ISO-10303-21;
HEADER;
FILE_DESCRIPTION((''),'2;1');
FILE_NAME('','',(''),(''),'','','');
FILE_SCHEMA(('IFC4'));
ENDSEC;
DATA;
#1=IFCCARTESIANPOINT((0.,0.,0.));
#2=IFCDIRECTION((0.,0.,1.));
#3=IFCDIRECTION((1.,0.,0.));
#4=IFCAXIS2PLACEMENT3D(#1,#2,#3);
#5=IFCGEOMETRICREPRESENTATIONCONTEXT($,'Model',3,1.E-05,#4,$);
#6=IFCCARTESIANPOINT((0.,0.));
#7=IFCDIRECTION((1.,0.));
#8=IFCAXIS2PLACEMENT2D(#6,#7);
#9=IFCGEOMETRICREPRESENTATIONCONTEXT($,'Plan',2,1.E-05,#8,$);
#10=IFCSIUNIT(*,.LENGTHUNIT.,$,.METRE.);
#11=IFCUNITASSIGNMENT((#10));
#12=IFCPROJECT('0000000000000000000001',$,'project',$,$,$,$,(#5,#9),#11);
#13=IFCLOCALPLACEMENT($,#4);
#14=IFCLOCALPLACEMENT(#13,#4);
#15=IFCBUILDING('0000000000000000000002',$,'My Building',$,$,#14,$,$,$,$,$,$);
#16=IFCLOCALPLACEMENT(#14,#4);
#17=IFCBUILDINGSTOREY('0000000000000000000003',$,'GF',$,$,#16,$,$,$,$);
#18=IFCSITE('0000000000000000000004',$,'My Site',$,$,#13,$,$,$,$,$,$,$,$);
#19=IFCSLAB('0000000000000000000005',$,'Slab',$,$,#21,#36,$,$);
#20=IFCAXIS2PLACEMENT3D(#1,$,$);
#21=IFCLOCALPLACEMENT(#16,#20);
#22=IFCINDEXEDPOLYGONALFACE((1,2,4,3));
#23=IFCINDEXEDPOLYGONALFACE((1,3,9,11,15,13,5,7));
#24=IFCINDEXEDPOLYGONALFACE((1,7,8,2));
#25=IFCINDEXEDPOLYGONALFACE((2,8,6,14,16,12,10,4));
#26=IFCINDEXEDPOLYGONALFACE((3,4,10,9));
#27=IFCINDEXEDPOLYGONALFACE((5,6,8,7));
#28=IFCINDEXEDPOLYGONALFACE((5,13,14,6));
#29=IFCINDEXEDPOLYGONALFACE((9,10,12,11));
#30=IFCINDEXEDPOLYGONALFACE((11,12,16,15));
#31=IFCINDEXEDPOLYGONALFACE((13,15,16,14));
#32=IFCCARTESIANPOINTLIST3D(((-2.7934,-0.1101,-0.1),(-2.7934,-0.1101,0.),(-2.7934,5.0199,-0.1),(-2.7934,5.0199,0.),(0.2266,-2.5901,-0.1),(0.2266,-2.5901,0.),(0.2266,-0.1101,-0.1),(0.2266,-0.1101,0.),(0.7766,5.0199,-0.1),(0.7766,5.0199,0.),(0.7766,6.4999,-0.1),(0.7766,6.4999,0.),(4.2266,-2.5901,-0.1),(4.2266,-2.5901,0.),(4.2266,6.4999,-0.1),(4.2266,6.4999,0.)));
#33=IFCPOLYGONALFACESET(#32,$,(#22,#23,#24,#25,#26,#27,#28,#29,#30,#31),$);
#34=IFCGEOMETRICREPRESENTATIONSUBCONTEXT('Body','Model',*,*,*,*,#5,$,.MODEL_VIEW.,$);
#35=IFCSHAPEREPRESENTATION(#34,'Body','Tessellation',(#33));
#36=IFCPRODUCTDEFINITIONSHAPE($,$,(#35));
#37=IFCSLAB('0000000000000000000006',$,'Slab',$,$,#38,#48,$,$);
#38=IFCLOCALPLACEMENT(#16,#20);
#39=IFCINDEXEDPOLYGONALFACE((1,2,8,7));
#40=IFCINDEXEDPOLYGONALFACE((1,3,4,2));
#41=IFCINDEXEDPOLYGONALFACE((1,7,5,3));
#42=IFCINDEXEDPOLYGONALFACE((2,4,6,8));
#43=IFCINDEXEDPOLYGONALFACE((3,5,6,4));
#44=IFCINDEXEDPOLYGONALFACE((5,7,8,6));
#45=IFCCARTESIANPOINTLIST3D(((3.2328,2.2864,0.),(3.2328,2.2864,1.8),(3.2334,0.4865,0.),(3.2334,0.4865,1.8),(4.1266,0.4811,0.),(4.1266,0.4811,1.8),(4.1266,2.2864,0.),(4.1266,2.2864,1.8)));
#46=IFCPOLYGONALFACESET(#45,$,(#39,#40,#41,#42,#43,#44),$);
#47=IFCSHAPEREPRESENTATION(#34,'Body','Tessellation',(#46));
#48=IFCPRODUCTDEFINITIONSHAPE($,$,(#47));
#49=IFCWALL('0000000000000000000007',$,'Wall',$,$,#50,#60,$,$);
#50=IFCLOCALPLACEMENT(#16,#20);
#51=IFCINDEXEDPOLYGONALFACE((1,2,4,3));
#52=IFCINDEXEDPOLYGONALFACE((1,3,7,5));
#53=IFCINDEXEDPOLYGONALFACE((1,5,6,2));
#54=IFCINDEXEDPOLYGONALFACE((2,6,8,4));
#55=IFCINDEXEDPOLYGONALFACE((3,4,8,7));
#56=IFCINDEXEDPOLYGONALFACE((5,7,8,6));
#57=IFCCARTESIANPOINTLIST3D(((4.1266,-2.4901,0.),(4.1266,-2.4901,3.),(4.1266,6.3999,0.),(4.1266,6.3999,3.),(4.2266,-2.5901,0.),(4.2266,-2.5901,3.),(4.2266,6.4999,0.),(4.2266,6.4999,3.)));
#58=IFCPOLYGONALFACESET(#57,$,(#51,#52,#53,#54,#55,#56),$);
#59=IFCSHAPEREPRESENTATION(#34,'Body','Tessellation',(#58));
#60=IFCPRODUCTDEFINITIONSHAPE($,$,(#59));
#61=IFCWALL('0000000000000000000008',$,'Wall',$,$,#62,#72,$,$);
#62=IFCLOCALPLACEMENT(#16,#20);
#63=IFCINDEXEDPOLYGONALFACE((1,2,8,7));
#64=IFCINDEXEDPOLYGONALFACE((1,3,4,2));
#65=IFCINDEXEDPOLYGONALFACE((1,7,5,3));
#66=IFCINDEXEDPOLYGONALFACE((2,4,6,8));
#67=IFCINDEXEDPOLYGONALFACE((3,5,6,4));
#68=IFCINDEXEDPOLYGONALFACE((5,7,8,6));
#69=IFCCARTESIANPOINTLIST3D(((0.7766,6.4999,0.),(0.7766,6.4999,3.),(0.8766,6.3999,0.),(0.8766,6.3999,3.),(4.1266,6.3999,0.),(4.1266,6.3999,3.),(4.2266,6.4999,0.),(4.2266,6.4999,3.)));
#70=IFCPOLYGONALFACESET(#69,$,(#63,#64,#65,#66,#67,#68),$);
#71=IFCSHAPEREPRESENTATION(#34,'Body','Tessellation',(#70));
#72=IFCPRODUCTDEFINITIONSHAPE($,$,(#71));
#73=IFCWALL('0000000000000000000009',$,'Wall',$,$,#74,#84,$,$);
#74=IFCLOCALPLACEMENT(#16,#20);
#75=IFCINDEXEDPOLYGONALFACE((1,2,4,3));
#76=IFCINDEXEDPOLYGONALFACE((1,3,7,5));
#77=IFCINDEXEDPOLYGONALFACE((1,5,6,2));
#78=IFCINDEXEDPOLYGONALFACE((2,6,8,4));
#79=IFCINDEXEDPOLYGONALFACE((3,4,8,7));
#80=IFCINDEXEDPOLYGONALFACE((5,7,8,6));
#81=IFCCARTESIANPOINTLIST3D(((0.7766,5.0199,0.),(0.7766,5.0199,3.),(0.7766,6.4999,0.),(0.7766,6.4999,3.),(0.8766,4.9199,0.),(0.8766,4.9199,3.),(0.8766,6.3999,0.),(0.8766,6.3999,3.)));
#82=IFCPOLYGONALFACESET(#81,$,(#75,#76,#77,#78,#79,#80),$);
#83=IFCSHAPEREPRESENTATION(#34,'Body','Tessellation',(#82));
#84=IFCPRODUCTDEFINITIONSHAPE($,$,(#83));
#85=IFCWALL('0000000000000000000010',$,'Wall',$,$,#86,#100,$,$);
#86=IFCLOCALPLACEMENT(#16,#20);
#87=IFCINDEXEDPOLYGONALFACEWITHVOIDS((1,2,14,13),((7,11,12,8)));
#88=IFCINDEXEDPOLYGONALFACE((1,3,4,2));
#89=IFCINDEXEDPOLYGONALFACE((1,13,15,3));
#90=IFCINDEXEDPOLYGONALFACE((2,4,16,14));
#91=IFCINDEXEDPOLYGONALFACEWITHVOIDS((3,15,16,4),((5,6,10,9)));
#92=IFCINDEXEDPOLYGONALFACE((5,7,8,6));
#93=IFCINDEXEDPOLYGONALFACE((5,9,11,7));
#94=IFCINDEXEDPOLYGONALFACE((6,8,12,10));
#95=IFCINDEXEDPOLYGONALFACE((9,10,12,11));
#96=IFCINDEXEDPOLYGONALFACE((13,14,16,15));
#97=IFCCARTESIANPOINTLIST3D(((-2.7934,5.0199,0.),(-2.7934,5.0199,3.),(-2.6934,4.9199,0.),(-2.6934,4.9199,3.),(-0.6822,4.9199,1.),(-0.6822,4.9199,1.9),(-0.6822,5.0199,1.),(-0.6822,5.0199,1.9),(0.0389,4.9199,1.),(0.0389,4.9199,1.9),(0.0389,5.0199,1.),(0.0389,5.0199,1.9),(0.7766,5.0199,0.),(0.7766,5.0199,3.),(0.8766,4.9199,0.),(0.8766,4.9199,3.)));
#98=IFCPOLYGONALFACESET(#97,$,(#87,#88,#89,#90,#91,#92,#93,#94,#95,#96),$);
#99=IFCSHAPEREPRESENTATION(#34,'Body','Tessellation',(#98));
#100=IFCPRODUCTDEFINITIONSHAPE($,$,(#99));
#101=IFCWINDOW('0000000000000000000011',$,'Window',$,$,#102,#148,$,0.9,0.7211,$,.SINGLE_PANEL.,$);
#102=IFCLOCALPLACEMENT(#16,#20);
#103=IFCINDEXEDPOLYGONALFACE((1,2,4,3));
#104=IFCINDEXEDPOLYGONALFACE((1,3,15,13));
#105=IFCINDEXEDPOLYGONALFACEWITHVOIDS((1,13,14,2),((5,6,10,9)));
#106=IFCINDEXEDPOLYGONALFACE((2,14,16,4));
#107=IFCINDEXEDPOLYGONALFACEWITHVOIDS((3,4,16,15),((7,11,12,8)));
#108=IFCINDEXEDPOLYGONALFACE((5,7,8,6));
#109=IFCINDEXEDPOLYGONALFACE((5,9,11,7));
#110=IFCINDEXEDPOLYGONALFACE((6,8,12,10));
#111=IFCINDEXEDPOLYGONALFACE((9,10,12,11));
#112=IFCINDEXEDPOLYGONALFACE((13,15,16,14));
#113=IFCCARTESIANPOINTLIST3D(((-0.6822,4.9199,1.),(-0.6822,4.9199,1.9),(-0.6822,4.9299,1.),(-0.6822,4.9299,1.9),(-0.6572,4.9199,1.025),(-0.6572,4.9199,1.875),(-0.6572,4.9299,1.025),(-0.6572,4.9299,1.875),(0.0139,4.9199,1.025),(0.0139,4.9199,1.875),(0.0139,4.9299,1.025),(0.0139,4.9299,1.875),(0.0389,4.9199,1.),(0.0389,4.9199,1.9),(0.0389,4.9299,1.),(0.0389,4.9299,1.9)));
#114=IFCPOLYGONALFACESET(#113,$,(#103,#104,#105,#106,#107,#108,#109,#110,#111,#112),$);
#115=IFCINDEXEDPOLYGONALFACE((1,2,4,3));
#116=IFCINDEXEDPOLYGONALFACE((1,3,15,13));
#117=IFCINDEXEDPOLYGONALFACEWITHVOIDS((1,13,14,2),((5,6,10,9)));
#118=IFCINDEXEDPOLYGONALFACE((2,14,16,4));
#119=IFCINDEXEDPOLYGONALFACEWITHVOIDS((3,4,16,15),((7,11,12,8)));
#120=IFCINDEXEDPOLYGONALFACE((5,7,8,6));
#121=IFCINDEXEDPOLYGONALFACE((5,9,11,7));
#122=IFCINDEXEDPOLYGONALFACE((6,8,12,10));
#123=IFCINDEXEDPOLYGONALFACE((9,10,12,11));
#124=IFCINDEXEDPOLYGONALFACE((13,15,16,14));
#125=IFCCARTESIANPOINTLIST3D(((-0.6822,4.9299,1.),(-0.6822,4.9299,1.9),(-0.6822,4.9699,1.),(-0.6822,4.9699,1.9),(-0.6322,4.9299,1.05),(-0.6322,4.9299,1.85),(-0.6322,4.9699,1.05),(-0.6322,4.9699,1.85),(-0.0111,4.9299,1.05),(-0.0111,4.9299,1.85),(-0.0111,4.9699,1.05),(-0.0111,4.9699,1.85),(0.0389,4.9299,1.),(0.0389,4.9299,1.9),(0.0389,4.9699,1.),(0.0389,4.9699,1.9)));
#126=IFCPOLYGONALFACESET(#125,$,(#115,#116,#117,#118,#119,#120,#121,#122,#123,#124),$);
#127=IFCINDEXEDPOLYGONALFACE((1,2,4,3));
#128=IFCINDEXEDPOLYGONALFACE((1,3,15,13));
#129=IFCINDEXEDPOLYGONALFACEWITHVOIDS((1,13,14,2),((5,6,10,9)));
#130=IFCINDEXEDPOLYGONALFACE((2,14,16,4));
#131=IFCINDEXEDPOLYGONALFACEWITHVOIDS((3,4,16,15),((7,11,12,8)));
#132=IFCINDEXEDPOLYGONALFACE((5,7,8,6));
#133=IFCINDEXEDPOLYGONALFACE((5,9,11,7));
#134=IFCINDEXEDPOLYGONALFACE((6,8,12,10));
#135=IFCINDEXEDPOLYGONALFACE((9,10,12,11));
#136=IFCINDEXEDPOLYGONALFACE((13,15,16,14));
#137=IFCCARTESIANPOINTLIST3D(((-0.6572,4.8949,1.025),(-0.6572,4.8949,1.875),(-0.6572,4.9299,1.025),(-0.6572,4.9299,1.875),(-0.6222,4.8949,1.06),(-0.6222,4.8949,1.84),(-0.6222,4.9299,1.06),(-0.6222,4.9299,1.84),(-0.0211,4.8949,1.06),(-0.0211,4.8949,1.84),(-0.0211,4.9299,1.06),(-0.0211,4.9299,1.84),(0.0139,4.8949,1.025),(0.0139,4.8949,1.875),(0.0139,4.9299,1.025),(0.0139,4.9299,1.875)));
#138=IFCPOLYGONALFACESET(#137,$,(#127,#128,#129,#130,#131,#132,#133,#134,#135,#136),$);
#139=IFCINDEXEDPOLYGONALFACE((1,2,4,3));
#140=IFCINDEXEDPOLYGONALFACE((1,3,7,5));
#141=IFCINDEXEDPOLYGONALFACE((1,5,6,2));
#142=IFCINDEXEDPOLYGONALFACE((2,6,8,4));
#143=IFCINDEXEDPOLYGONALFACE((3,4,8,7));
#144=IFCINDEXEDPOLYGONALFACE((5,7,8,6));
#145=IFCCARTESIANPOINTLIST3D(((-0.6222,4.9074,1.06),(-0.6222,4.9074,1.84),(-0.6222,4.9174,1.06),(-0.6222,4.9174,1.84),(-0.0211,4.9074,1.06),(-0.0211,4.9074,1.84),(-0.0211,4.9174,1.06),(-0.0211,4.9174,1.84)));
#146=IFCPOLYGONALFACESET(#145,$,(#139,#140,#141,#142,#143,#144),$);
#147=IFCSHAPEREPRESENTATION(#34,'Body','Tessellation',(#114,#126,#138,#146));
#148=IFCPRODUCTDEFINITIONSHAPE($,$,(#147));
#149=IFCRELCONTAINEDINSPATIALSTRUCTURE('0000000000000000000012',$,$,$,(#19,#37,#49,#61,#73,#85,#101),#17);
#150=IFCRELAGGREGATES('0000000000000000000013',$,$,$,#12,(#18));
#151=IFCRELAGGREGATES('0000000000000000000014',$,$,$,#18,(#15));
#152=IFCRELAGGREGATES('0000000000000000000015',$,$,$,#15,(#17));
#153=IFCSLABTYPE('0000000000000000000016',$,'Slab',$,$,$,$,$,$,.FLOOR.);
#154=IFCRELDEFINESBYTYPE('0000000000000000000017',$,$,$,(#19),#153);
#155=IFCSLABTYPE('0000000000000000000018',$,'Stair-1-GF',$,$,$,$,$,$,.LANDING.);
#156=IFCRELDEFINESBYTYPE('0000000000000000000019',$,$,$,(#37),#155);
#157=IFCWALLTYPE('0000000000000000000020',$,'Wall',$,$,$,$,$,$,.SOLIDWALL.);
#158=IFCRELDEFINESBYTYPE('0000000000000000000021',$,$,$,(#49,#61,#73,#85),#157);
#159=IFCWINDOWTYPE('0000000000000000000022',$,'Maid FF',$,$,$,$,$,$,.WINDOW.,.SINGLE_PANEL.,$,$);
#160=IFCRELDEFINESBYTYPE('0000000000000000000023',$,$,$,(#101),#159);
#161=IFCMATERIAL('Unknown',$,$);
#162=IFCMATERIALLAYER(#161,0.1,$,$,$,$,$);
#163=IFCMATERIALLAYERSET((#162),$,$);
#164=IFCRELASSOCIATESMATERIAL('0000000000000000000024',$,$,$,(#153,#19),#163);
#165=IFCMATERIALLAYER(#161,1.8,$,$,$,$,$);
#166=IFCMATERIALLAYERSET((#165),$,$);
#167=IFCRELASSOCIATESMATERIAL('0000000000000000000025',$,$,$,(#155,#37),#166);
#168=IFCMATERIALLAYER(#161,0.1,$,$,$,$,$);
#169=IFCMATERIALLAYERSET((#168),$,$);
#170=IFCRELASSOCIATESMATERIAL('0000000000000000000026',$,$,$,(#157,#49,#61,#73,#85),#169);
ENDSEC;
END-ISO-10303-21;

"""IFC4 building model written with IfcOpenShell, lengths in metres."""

from ifc_helpers import new_model, entity, si_unit, frame, origin_with_axes, origin_2d_with_axis, place, context, subcontext, project, spatial, line, indexed_curve, outline, extrude, shape, source, transform, mapped, material, layer, layer_set, layer_usage, type_object, type_shapes, element, fill, save


model = new_model("IFC4")

# Units and contexts
model_context = context("Model", 3, precision=1e-05, world=origin_with_axes())
plan_context = context("Plan", 2, precision=1e-05, world=origin_2d_with_axis())
body_context_1 = subcontext(model_context, "Body", "Model", "MODEL_VIEW")
body_context_2 = subcontext(plan_context, "Body", "Plan", "PLAN_VIEW")
ifc_project = project(units=[si_unit("LENGTHUNIT", "METRE")], contexts=[model_context, plan_context])

# Site, building, storey
site_placement = place(None, origin_with_axes())
site = spatial("IfcSite", under=ifc_project, at=site_placement, Name="My Site")
building_placement = place(site_placement, origin_with_axes())
building = spatial("IfcBuilding", under=site, at=building_placement, Name="My Building")
storey_placement = place(building_placement, origin_with_axes())
storey = spatial("IfcBuildingStorey", under=building, at=storey_placement, Name="GF")

# Slabs
ifc_material_1 = material(Name="Unknown")
ifc_layer_1 = layer(ifc_material_1, 0.1)
ifc_layer_set_1 = layer_set([ifc_layer_1])
ifc_layer_usage_1 = layer_usage(ifc_layer_set_1, "AXIS3", "POSITIVE", -0.1)
slab_type_1 = type_object("IfcSlabType", Name="Slab", PredefinedType="FLOOR", material=ifc_layer_set_1)
slab_1_placement = place(storey_placement, frame((4.2266, -2.5901, 0.0), z_axis=(0.0, 0.0, 1.0), x_axis=(1.0, 0.0, 0.0)))
element("IfcSlab", 1, at=slab_1_placement, inside=storey, type_object=slab_type_1, material=ifc_layer_usage_1, Name="Slab", context=body_context_1, shape_type="SweptSolid", body=[
    extrude(outline(indexed_curve([(0.0, 0.0), (0.0, 9.09), (-3.45, 9.09), (-3.45, 7.61), (-7.02, 7.61), (-7.02, 2.48), (-4.0, 2.48), (-4.0, 0.0), (0.0, 0.0)])), frame((0.0, 0.0, -0.1), z_axis=(0.0, 0.0, 1.0), x_axis=(1.0, 0.0, 0.0)), (0.0, 0.0, 1.0), 0.1),
])
ifc_layer_2 = layer(ifc_material_1, 1.8)
ifc_layer_set_2 = layer_set([ifc_layer_2])
ifc_layer_usage_2 = layer_usage(ifc_layer_set_2, "AXIS3", "POSITIVE", -0.1)
slab_type_2 = type_object("IfcSlabType", Name="Stair-1-GF", PredefinedType="LANDING", material=ifc_layer_set_2)
slab_2_placement = place(storey_placement, frame((3.2334, 0.4865, 0.1), z_axis=(0.0, 0.0, 1.0), x_axis=(1.0, 0.0, 0.0)))
element("IfcSlab", 2, at=slab_2_placement, inside=storey, type_object=slab_type_2, material=ifc_layer_usage_2, Name="Slab", context=body_context_1, shape_type="SweptSolid", body=[
    extrude(outline(indexed_curve([(-0.0006, 1.7999), (0.8932, 1.7999), (0.8932, -0.0054), (0.0, 0.0), (-0.0006, 1.7999)])), frame((0.0, 0.0, -0.1), z_axis=(0.0, 0.0, 1.0), x_axis=(1.0, 0.0, 0.0)), (0.0, 0.0, 1.0), 1.8),
])

# Shared definitions
ifc_layer_3 = layer(ifc_material_1, 0.1)
ifc_layer_set_3 = layer_set([ifc_layer_3])
wall_type = type_object("IfcWallType", Name="Wall", PredefinedType="SOLIDWALL", material=ifc_layer_set_3)

# Walls
ifc_layer_usage_3 = layer_usage(ifc_layer_set_3, "AXIS2", "POSITIVE", 0.0)
wall_1_placement = place(storey_placement, frame((4.2266, -2.5901, 0.0), z_axis=(0.0, 0.0, 1.0), x_axis=(0.0, 1.0, 0.0)))
element("IfcWall", 3, at=wall_1_placement, inside=storey, type_object=wall_type, material=ifc_layer_usage_3, Name="Wall", context=body_context_1, shape_type="SweptSolid", body=[
    extrude(outline(indexed_curve([(0.0, 0.0), (0.1, 0.1), (8.99, 0.1), (9.09, 0.0)], segments=[line(1, 2, 3, 4, 1)])), origin_with_axes(), (0.0, 0.0, 1.0), 3.0),
])
ifc_layer_usage_4 = layer_usage(ifc_layer_set_3, "AXIS2", "POSITIVE", 0.0)
wall_2_placement = place(storey_placement, frame((4.2266, 6.4999, 0.0), z_axis=(0.0, 0.0, 1.0), x_axis=(-1.0, 0.0, 0.0)))
element("IfcWall", 4, at=wall_2_placement, inside=storey, type_object=wall_type, material=ifc_layer_usage_4, Name="Wall", context=body_context_1, shape_type="SweptSolid", body=[
    extrude(outline(indexed_curve([(0.0, 0.0), (0.1, 0.1), (3.35, 0.1), (3.45, 0.0)], segments=[line(1, 2, 3, 4, 1)])), origin_with_axes(), (0.0, 0.0, 1.0), 3.0),
])
ifc_layer_usage_5 = layer_usage(ifc_layer_set_3, "AXIS2", "POSITIVE", 0.0)
wall_3_placement = place(storey_placement, frame((0.7766, 6.4999, 0.0), z_axis=(0.0, 0.0, 1.0), x_axis=(0.0, -1.0, 0.0)))
element("IfcWall", 5, at=wall_3_placement, inside=storey, type_object=wall_type, material=ifc_layer_usage_5, Name="Wall", context=body_context_1, shape_type="SweptSolid", body=[
    extrude(outline(indexed_curve([(0.0, 0.0), (0.1, 0.1), (1.58, 0.1), (1.48, 0.0)], segments=[line(1, 2, 3, 4, 1)])), origin_with_axes(), (0.0, 0.0, 1.0), 3.0),
])

# Wall, opening, window
ifc_layer_usage_6 = layer_usage(ifc_layer_set_3, "AXIS2", "POSITIVE", 0.0)
wall_4_placement = place(storey_placement, frame((0.7766, 5.0199, 0.0), z_axis=(0.0, 0.0, 1.0), x_axis=(-1.0, 0.0, 0.0)))
wall_4 = element("IfcWall", 6, at=wall_4_placement, inside=storey, type_object=wall_type, material=ifc_layer_usage_6, Name="Wall", context=body_context_1, shape_type="SweptSolid", body=[
    extrude(outline(indexed_curve([(0.0, 0.0), (-0.1, 0.1), (3.47, 0.1), (3.57, 0.0)], segments=[line(1, 2, 3, 4, 1)])), origin_with_axes(), (0.0, 0.0, 1.0), 3.0),
])
shared_shape_1 = source(origin_with_axes(), body_context_1, "Body", "SweptSolid", [
    extrude(outline(indexed_curve([(0.0, 0.0), (0.7211, 0.0), (0.7211, 0.9), (0.0, 0.9)], segments=[line(1, 2, 3, 4, 1)])), frame((0.0, -0.6, 0.0), z_axis=(0.0, -1.0, 0.0), x_axis=(1.0, 0.0, 0.0)), (0.0, 0.0, -1.0), 1.2),
])
opening_1_placement = place(wall_4_placement, frame((0.7377, 0.0, 1.0), z_axis=(0.0, 0.0, 1.0), x_axis=(1.0, 0.0, 0.0)))
opening_1 = element("IfcOpeningElement", 7, at=opening_1_placement, cuts=wall_4, PredefinedType="OPENING", context=body_context_1, shape_type="MappedRepresentation", body=[
    mapped(shared_shape_1, transform((0.0, 0.0, 0.0), x_axis=(1.0, 0.0, 0.0), y_axis=(0.0, 1.0, 0.0), z_axis=(0.0, 0.0, 1.0), scale=1.0)),
])
window_type_1 = type_object("IfcWindowType", Name="Maid FF", PartitioningType="SINGLE_PANEL", PredefinedType="WINDOW")
shared_shape_2 = source(origin_with_axes(), body_context_1, "Body", "SweptSolid", [
    extrude(outline(indexed_curve([(0.0, 0.0), (0.7211, 0.0), (0.7211, 0.9), (0.0, 0.9)], segments=[line(1, 2, 3, 4, 1)]), holes=[indexed_curve([(0.025, 0.025), (0.6961, 0.025), (0.6961, 0.875), (0.025, 0.875)], segments=[line(1, 2, 3, 4, 1)])]), frame((0.0, 0.09, 0.0), z_axis=(0.0, -1.0, 0.0), x_axis=(1.0, 0.0, 0.0)), (0.0, 0.0, -1.0), 0.01),
    extrude(outline(indexed_curve([(0.0, 0.0), (0.7211, 0.0), (0.7211, 0.9), (0.0, 0.9)], segments=[line(1, 2, 3, 4, 1)]), holes=[indexed_curve([(0.05, 0.05), (0.6711, 0.05), (0.6711, 0.85), (0.05, 0.85)], segments=[line(1, 2, 3, 4, 1)])]), frame((0.0, 0.05, 0.0), z_axis=(0.0, -1.0, 0.0), x_axis=(1.0, 0.0, 0.0)), (0.0, 0.0, -1.0), 0.04),
    extrude(outline(indexed_curve([(0.0, 0.0), (0.6711, 0.0), (0.6711, 0.85), (0.0, 0.85)], segments=[line(1, 2, 3, 4, 1)]), holes=[indexed_curve([(0.035, 0.035), (0.6361, 0.035), (0.6361, 0.815), (0.035, 0.815)], segments=[line(1, 2, 3, 4, 1)])]), frame((0.025, 0.09, 0.025), z_axis=(0.0, -1.0, 0.0), x_axis=(1.0, 0.0, 0.0)), (0.0, 0.0, -1.0), 0.035),
    extrude(outline(indexed_curve([(0.035, 0.035), (0.6361, 0.035), (0.6361, 0.815), (0.035, 0.815)], segments=[line(1, 2, 3, 4, 1)])), frame((0.025, 0.1025, 0.025), z_axis=(0.0, -1.0, 0.0), x_axis=(1.0, 0.0, 0.0)), (0.0, 0.0, -1.0), 0.01),
])
shared_shape_3 = source(origin_with_axes(), body_context_2, "Body", "Curve2D", [
    entity("IfcIndexedPolyCurve", entity("IfcCartesianPointList2D", [[0.05, 0.05], [0.6711, 0.05]])),
    entity("IfcIndexedPolyCurve", entity("IfcCartesianPointList2D", [[0.0, 0.1], [0.025, 0.1], [0.025, 0.09], [0.05, 0.09], [0.05, 0.05], [0.0, 0.05]]), [entity("IfcLineIndex", [1, 2, 3, 4, 5, 6, 1])]),
    entity("IfcIndexedPolyCurve", entity("IfcCartesianPointList2D", [[0.7211, 0.1], [0.6961, 0.1], [0.6961, 0.09], [0.6711, 0.09], [0.6711, 0.05], [0.7211, 0.05]]), [entity("IfcLineIndex", [1, 2, 3, 4, 5, 6, 1])]),
    entity("IfcIndexedPolyCurve", entity("IfcCartesianPointList2D", [[0.025, 0.09], [0.06, 0.09], [0.06, 0.125], [0.025, 0.125]]), [entity("IfcLineIndex", [1, 2, 3, 4, 1])]),
    entity("IfcIndexedPolyCurve", entity("IfcCartesianPointList2D", [[0.6961, 0.09], [0.6611, 0.09], [0.6611, 0.125], [0.6961, 0.125]]), [entity("IfcLineIndex", [1, 2, 3, 4, 1])]),
    entity("IfcIndexedPolyCurve", entity("IfcCartesianPointList2D", [[0.06, 0.09], [0.6611, 0.09]])),
    entity("IfcIndexedPolyCurve", entity("IfcCartesianPointList2D", [[0.06, 0.125], [0.6611, 0.125]])),
    entity("IfcIndexedPolyCurve", entity("IfcCartesianPointList2D", [[0.06, 0.1075], [0.6611, 0.1075]])),
])
type_shapes(window_type_1, [shared_shape_2, shared_shape_3])
window_1_placement = place(opening_1_placement, frame((0.0, 0.0, 0.0), z_axis=(0.0, 0.0, 1.0), x_axis=(1.0, 0.0, 0.0)))
window_1 = element("IfcWindow", 8, at=window_1_placement, inside=storey, type_object=window_type_1, Name="Window", OverallHeight=0.9, OverallWidth=0.7211, PartitioningType="SINGLE_PANEL", shapes=[
    shape(body_context_1, "Body", "MappedRepresentation", [mapped(shared_shape_2, transform((0.0, 0.0, 0.0), x_axis=(1.0, 0.0, 0.0), y_axis=(0.0, 1.0, 0.0), z_axis=(0.0, 0.0, 1.0), scale=1.0))]),
    shape(body_context_2, "Body", "MappedRepresentation", [mapped(shared_shape_3, transform((0.0, 0.0, 0.0), x_axis=(1.0, 0.0, 0.0), y_axis=(0.0, 1.0, 0.0), z_axis=(0.0, 0.0, 1.0), scale=1.0))]),
])
fill(opening_1, window_1)

save(model, "model.ifc")
